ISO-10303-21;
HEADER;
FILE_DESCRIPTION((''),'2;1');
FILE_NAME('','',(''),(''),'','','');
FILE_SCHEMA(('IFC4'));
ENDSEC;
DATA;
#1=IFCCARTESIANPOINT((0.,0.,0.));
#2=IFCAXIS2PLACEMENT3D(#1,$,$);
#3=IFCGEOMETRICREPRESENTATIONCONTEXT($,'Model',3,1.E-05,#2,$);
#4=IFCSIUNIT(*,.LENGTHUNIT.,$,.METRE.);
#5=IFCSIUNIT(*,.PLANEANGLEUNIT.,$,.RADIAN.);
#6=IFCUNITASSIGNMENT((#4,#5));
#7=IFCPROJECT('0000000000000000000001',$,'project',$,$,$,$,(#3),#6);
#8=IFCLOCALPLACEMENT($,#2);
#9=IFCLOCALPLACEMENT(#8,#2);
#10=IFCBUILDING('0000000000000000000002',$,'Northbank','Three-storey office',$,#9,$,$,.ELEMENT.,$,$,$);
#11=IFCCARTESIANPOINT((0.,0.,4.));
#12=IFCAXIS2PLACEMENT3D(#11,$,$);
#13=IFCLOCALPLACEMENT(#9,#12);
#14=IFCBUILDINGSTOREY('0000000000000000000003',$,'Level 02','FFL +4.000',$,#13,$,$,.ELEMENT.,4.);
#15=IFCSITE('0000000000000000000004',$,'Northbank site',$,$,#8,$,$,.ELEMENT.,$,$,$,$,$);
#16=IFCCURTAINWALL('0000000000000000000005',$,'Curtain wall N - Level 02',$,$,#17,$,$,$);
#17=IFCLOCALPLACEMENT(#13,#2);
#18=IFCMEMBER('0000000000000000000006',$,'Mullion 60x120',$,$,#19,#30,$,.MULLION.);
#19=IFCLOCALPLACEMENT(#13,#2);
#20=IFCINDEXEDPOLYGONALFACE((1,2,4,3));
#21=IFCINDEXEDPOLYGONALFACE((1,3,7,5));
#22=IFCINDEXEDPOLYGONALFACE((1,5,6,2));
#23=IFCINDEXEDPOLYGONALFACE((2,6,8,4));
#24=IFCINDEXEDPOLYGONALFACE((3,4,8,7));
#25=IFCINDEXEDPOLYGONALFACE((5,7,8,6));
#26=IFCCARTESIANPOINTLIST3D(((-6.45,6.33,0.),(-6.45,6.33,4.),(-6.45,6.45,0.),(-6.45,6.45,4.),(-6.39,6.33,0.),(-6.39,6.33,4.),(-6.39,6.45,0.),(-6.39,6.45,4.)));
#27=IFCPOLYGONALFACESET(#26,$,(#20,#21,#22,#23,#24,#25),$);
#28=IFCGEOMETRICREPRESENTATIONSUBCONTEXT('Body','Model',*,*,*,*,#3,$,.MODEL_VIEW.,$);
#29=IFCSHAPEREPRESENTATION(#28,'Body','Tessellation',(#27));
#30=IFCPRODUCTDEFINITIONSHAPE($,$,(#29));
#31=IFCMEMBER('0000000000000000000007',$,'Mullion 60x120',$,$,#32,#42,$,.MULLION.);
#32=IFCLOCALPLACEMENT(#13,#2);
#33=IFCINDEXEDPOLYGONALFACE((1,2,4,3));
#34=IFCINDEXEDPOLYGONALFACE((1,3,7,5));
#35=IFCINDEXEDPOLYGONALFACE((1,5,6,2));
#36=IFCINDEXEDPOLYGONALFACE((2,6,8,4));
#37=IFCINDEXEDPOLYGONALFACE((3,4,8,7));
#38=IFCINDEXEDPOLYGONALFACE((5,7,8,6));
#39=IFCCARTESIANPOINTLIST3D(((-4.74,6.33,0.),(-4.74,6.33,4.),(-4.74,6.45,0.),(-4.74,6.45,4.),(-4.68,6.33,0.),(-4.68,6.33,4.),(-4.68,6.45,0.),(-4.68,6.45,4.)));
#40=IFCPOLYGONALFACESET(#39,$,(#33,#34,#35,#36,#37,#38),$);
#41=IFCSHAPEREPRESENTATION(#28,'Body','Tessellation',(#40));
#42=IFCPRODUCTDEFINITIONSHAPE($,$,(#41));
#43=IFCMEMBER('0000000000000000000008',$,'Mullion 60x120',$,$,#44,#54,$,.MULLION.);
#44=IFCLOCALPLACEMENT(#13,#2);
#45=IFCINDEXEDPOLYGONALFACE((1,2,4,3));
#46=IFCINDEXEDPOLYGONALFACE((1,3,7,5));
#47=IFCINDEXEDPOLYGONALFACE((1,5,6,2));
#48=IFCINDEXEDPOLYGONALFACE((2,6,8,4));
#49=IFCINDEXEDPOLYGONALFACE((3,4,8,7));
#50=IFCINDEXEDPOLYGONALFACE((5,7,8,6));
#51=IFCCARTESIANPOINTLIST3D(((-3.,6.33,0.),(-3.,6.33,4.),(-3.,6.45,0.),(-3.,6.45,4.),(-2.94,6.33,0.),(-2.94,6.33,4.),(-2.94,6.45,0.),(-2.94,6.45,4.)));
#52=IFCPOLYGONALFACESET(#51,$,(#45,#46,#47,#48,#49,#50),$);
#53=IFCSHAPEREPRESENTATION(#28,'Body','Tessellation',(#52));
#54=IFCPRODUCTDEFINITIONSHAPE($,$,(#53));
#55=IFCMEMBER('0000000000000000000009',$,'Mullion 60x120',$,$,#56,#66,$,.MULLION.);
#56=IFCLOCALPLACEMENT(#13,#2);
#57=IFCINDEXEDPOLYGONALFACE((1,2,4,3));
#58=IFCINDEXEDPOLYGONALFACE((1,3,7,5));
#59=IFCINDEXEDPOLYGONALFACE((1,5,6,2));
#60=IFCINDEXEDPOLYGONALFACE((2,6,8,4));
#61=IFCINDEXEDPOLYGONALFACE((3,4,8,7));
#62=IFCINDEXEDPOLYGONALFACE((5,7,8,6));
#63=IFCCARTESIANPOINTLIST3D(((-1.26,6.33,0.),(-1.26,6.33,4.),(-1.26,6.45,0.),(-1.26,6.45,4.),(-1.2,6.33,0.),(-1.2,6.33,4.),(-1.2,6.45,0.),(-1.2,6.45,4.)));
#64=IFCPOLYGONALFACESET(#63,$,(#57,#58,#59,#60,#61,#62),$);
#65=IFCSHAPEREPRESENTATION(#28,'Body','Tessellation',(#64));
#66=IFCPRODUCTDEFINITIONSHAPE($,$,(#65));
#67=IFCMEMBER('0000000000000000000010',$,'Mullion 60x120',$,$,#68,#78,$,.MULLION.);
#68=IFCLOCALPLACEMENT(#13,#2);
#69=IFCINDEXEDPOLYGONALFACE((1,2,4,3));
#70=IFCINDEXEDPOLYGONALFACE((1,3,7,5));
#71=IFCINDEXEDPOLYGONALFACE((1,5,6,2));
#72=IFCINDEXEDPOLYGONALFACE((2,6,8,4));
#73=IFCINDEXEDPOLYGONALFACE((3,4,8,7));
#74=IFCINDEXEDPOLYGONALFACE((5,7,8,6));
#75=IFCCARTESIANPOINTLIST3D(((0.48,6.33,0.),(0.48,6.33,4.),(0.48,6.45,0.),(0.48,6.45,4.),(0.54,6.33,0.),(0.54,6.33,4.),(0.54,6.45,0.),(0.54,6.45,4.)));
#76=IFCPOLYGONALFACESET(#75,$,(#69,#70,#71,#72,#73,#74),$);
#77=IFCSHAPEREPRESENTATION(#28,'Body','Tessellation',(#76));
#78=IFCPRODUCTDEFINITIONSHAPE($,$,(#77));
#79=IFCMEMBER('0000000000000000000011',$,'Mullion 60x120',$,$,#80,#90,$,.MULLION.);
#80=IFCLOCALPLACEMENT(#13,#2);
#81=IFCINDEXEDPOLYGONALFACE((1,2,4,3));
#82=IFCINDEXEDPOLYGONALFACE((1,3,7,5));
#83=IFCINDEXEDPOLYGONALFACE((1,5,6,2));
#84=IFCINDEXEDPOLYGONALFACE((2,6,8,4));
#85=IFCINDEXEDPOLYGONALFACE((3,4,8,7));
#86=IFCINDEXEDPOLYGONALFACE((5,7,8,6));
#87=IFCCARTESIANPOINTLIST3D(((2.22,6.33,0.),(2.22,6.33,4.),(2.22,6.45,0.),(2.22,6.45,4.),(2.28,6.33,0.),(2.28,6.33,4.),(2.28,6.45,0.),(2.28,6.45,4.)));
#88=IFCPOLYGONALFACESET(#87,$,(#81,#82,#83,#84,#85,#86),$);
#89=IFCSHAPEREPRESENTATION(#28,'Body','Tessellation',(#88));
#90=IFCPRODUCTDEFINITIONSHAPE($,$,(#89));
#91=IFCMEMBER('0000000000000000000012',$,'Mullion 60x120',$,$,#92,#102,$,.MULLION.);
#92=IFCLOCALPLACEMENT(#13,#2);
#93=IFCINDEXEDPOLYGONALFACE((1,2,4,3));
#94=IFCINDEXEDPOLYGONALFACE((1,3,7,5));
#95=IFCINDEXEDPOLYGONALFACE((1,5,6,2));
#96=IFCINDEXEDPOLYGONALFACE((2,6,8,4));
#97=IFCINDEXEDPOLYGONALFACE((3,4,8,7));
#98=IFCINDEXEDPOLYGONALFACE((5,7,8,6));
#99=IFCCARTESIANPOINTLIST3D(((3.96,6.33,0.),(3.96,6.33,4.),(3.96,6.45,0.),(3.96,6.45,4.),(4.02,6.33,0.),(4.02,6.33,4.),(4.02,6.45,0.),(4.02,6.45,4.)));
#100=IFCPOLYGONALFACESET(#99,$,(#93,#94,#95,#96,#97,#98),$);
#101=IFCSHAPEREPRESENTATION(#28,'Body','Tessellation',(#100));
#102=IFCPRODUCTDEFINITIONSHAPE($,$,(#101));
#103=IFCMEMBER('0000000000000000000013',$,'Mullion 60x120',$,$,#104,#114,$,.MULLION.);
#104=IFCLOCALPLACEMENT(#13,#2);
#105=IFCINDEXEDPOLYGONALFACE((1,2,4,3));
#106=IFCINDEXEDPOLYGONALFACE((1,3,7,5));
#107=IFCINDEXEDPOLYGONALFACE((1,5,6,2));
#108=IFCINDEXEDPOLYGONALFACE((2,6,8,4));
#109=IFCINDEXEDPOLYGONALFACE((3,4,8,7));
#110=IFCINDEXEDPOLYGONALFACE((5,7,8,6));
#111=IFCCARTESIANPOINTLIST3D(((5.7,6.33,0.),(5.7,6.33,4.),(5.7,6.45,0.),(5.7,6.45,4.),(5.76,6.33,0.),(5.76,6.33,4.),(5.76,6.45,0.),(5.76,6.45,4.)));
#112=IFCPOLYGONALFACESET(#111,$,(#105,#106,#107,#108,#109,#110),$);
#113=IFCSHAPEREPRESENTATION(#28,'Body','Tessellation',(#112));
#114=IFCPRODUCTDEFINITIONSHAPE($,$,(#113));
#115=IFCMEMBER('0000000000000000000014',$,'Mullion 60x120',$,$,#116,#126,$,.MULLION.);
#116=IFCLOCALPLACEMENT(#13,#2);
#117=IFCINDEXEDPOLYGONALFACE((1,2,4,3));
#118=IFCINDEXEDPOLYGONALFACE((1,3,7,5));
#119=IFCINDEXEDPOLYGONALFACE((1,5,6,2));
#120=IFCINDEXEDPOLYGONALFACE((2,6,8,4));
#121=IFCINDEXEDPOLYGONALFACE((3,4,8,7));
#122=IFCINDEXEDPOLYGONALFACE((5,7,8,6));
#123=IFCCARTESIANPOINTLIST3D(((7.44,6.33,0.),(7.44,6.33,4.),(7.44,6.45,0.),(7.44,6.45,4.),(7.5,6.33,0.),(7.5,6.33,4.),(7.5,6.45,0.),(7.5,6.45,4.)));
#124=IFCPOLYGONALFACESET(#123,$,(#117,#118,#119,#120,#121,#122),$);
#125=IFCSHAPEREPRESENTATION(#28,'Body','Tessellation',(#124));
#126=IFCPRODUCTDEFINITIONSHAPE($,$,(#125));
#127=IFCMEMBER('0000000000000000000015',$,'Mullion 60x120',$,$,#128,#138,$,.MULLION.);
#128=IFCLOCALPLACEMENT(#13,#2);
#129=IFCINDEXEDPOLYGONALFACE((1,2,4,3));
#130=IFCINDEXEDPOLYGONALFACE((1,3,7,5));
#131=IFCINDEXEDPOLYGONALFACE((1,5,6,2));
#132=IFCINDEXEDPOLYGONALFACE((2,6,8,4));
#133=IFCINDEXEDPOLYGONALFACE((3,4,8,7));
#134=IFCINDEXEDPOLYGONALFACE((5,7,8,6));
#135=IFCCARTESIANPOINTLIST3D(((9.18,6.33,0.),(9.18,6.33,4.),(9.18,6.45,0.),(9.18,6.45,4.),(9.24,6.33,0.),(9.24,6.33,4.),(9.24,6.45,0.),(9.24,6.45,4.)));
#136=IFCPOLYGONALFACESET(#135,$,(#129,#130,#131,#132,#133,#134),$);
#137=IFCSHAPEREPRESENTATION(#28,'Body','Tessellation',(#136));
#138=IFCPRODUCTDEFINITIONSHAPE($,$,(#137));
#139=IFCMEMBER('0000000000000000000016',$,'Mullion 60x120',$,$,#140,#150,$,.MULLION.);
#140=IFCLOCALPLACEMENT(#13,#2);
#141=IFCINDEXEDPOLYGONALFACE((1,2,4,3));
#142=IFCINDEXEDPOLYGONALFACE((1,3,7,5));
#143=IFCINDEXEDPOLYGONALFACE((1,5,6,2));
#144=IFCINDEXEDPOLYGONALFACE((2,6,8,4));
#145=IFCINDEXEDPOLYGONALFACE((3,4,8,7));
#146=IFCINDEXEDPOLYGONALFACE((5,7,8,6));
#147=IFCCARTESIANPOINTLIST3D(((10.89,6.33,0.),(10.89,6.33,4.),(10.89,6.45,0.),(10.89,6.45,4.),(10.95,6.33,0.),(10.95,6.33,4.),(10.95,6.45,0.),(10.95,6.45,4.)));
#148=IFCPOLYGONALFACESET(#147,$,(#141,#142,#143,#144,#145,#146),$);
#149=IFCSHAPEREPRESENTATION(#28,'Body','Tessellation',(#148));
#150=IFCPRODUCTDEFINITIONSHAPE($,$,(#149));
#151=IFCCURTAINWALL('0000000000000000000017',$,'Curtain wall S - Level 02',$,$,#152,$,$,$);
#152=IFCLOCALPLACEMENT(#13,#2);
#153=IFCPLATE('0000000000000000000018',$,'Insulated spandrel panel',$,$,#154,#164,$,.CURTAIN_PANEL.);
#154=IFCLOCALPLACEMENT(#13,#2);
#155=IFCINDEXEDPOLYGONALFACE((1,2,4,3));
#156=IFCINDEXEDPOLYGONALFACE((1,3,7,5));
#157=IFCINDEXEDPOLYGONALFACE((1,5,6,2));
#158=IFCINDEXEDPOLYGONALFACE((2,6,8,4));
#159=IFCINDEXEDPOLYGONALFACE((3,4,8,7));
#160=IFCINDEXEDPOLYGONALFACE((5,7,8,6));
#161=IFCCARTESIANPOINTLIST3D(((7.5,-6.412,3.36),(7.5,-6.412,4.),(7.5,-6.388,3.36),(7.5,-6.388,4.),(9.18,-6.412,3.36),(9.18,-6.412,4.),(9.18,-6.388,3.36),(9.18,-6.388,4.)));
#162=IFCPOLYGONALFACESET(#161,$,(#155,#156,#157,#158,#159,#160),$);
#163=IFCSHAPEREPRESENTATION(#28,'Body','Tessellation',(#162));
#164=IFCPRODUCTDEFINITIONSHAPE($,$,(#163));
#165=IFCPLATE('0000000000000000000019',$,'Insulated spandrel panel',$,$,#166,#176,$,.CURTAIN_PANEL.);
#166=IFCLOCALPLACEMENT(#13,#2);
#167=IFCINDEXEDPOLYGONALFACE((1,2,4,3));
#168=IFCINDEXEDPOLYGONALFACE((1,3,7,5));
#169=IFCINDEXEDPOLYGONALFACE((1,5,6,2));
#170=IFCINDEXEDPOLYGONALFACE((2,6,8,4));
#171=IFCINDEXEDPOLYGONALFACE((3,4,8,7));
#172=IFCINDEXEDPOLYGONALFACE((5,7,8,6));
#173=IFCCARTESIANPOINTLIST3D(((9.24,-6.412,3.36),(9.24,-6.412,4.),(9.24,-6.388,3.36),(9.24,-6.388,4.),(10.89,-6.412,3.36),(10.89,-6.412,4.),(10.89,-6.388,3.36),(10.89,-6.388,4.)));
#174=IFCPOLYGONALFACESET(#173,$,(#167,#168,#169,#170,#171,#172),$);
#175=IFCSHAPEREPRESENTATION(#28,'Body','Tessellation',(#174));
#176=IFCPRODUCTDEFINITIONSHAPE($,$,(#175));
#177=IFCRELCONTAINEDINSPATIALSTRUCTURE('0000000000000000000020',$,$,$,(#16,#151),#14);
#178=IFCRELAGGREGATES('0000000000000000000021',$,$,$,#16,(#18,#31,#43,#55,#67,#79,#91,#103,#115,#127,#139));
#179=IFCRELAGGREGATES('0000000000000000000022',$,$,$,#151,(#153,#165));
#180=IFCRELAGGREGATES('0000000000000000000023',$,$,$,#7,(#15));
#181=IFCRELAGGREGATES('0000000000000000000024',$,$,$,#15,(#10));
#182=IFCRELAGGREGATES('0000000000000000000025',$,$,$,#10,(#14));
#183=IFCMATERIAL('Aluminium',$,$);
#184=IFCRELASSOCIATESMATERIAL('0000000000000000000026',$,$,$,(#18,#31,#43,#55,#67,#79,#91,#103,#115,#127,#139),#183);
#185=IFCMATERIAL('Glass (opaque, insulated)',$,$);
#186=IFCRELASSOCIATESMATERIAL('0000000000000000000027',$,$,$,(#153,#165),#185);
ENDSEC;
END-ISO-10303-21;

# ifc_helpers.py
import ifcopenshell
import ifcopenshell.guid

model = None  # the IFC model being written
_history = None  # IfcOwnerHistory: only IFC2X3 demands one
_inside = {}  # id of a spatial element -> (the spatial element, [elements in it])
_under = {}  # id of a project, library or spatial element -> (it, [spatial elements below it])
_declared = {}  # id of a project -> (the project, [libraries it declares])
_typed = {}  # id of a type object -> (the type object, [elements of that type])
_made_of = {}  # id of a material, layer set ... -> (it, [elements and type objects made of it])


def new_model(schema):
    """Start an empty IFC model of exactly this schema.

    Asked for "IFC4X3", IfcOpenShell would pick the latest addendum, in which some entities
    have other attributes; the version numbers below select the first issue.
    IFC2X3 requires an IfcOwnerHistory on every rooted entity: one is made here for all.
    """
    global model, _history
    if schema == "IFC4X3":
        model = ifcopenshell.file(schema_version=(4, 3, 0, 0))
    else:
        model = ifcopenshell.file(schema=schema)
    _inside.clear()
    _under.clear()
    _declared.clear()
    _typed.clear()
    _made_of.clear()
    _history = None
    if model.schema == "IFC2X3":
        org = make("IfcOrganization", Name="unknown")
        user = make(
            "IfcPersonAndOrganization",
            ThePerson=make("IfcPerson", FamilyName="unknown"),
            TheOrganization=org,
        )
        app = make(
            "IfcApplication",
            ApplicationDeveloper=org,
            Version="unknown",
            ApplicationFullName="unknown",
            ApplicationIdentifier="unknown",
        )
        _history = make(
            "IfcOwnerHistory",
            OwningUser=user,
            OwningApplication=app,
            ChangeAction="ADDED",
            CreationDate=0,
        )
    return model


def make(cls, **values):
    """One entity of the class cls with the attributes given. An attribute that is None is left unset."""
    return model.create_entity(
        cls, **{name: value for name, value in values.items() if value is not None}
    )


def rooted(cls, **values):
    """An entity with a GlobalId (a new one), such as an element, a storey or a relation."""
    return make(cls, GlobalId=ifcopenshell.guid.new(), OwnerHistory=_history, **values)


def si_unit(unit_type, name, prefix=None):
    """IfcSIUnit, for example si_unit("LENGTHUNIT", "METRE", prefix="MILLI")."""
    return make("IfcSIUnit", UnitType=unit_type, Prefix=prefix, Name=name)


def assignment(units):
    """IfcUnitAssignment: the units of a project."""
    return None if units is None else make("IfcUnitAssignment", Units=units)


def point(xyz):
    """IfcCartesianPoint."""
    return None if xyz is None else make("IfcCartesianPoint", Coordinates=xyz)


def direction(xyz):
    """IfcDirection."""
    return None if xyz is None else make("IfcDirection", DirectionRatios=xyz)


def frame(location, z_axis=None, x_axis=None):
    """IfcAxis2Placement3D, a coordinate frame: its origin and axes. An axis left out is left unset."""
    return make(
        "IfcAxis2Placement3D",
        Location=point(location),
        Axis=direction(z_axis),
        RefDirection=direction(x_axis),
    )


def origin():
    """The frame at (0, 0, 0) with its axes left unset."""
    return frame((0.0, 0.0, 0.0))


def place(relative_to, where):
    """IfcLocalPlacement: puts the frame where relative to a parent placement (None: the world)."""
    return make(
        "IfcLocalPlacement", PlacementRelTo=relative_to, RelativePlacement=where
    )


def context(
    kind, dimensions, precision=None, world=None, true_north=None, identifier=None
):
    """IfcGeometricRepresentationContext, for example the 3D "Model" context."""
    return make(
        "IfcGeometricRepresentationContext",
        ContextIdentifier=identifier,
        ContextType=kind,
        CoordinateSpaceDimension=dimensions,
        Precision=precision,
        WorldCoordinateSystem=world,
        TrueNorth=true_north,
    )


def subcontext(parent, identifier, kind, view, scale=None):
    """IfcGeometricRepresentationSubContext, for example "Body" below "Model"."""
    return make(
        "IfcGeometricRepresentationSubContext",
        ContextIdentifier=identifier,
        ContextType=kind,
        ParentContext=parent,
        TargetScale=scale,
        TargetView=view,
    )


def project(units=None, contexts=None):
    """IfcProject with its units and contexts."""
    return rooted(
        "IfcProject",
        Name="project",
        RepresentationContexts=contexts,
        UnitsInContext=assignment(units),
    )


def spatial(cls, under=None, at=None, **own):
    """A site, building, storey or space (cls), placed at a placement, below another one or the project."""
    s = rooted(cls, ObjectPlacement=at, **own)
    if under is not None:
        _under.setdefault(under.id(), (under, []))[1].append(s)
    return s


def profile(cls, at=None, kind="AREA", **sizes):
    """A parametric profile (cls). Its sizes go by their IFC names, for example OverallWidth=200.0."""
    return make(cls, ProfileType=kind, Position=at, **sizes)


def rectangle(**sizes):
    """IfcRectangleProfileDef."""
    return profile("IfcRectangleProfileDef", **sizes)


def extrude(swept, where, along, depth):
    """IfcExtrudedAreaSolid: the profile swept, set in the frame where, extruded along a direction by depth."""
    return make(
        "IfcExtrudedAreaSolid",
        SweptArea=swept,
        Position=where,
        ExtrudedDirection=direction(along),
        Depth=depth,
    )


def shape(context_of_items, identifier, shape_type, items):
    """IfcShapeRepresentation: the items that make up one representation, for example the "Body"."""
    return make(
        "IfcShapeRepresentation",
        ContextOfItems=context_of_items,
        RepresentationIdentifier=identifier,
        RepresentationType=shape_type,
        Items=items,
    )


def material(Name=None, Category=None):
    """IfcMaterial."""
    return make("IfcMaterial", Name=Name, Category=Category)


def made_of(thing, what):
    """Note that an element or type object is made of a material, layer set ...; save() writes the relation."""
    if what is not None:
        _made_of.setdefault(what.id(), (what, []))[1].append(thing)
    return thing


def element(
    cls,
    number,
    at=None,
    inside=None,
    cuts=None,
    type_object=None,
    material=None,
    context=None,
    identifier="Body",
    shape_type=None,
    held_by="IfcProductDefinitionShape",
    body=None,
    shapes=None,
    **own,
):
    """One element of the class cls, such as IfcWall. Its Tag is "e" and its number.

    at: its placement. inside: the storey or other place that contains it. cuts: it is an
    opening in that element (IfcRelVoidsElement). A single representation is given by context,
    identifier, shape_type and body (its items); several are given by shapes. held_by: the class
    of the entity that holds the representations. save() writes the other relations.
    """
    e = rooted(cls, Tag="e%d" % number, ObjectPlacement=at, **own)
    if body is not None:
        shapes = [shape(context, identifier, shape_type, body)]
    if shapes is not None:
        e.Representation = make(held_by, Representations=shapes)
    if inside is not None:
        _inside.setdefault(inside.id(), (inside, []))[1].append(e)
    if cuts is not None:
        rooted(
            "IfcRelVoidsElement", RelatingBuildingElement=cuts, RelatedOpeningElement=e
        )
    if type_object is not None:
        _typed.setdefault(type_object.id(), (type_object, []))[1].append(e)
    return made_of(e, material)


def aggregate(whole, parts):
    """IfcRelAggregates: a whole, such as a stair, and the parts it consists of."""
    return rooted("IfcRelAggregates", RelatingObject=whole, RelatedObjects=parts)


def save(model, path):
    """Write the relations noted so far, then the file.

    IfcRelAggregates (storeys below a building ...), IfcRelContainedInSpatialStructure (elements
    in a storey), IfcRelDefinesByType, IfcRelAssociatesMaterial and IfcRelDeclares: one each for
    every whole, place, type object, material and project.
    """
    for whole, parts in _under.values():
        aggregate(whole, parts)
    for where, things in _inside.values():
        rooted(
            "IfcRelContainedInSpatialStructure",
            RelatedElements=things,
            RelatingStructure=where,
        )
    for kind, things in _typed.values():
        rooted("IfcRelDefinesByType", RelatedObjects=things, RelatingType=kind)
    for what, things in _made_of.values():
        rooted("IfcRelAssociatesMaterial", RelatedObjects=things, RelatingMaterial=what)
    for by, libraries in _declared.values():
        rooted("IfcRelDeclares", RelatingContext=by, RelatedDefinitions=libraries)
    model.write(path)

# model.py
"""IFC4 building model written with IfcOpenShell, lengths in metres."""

from ifc_helpers import new_model, si_unit, frame, origin, place, context, subcontext, project, spatial, rectangle, extrude, material, element, aggregate, save


model = new_model("IFC4")

# Units and contexts
model_context = context("Model", 3, precision=1e-05, world=origin())
body_context = subcontext(model_context, "Body", "Model", "MODEL_VIEW")
ifc_project = project(units=[si_unit("LENGTHUNIT", "METRE"), si_unit("PLANEANGLEUNIT", "RADIAN")], contexts=[model_context])

# Site, building, storey
site_placement = place(None, origin())
site = spatial("IfcSite", under=ifc_project, at=site_placement, Name="Northbank site", CompositionType="ELEMENT")
building_placement = place(site_placement, origin())
building = spatial("IfcBuilding", under=site, at=building_placement, Name="Northbank", Description="Three-storey office", CompositionType="ELEMENT")
storey_placement = place(building_placement, frame((0.0, 0.0, 4.0)))
storey = spatial("IfcBuildingStorey", under=building, at=storey_placement, Name="Level 02", Description="FFL +4.000", CompositionType="ELEMENT", Elevation=4.0)

# Curtain wall, members
curtain_wall_1_placement = place(storey_placement, frame((0.0, 0.0, -4.0)))
curtain_wall_1 = element("IfcCurtainWall", 1, at=curtain_wall_1_placement, inside=storey, Name="Curtain wall N - Level 02")
ifc_material_1 = material(Name="Aluminium")
member_1_placement = place(storey_placement, frame((0.0, 0.0, -4.0)))
member_1 = element("IfcMember", 2, at=member_1_placement, material=ifc_material_1, Name="Mullion 60x120", PredefinedType="MULLION", context=body_context, shape_type="SweptSolid", body=[
    extrude(rectangle(XDim=0.06, YDim=0.12), frame((-6.42, 6.39, 4.0)), (0.0, 0.0, 1.0), 4.0),
])
member_2_placement = place(storey_placement, frame((0.0, 0.0, -4.0)))
member_2 = element("IfcMember", 3, at=member_2_placement, material=ifc_material_1, Name="Mullion 60x120", PredefinedType="MULLION", context=body_context, shape_type="SweptSolid", body=[
    extrude(rectangle(XDim=0.06, YDim=0.12), frame((-4.71, 6.39, 4.0)), (0.0, 0.0, 1.0), 4.0),
])
member_3_placement = place(storey_placement, frame((0.0, 0.0, -4.0)))
member_3 = element("IfcMember", 4, at=member_3_placement, material=ifc_material_1, Name="Mullion 60x120", PredefinedType="MULLION", context=body_context, shape_type="SweptSolid", body=[
    extrude(rectangle(XDim=0.06, YDim=0.12), frame((-2.97, 6.39, 4.0)), (0.0, 0.0, 1.0), 4.0),
])
member_4_placement = place(storey_placement, frame((0.0, 0.0, -4.0)))
member_4 = element("IfcMember", 5, at=member_4_placement, material=ifc_material_1, Name="Mullion 60x120", PredefinedType="MULLION", context=body_context, shape_type="SweptSolid", body=[
    extrude(rectangle(XDim=0.06, YDim=0.12), frame((-1.23, 6.39, 4.0)), (0.0, 0.0, 1.0), 4.0),
])
member_5_placement = place(storey_placement, frame((0.0, 0.0, -4.0)))
member_5 = element("IfcMember", 6, at=member_5_placement, material=ifc_material_1, Name="Mullion 60x120", PredefinedType="MULLION", context=body_context, shape_type="SweptSolid", body=[
    extrude(rectangle(XDim=0.06, YDim=0.12), frame((0.51, 6.39, 4.0)), (0.0, 0.0, 1.0), 4.0),
])
member_6_placement = place(storey_placement, frame((0.0, 0.0, -4.0)))
member_6 = element("IfcMember", 7, at=member_6_placement, material=ifc_material_1, Name="Mullion 60x120", PredefinedType="MULLION", context=body_context, shape_type="SweptSolid", body=[
    extrude(rectangle(XDim=0.06, YDim=0.12), frame((2.25, 6.39, 4.0)), (0.0, 0.0, 1.0), 4.0),
])
member_7_placement = place(storey_placement, frame((0.0, 0.0, -4.0)))
member_7 = element("IfcMember", 8, at=member_7_placement, material=ifc_material_1, Name="Mullion 60x120", PredefinedType="MULLION", context=body_context, shape_type="SweptSolid", body=[
    extrude(rectangle(XDim=0.06, YDim=0.12), frame((3.99, 6.39, 4.0)), (0.0, 0.0, 1.0), 4.0),
])
member_8_placement = place(storey_placement, frame((0.0, 0.0, -4.0)))
member_8 = element("IfcMember", 9, at=member_8_placement, material=ifc_material_1, Name="Mullion 60x120", PredefinedType="MULLION", context=body_context, shape_type="SweptSolid", body=[
    extrude(rectangle(XDim=0.06, YDim=0.12), frame((5.73, 6.39, 4.0)), (0.0, 0.0, 1.0), 4.0),
])
member_9_placement = place(storey_placement, frame((0.0, 0.0, -4.0)))
member_9 = element("IfcMember", 10, at=member_9_placement, material=ifc_material_1, Name="Mullion 60x120", PredefinedType="MULLION", context=body_context, shape_type="SweptSolid", body=[
    extrude(rectangle(XDim=0.06, YDim=0.12), frame((7.47, 6.39, 4.0)), (0.0, 0.0, 1.0), 4.0),
])
member_10_placement = place(storey_placement, frame((0.0, 0.0, -4.0)))
member_10 = element("IfcMember", 11, at=member_10_placement, material=ifc_material_1, Name="Mullion 60x120", PredefinedType="MULLION", context=body_context, shape_type="SweptSolid", body=[
    extrude(rectangle(XDim=0.06, YDim=0.12), frame((9.21, 6.39, 4.0)), (0.0, 0.0, 1.0), 4.0),
])
member_11_placement = place(storey_placement, frame((0.0, 0.0, -4.0)))
member_11 = element("IfcMember", 12, at=member_11_placement, material=ifc_material_1, Name="Mullion 60x120", PredefinedType="MULLION", context=body_context, shape_type="SweptSolid", body=[
    extrude(rectangle(XDim=0.06, YDim=0.12), frame((10.92, 6.39, 4.0)), (0.0, 0.0, 1.0), 4.0),
])
aggregate(curtain_wall_1, [member_1, member_2, member_3, member_4, member_5, member_6, member_7, member_8, member_9, member_10, member_11])

# Curtain wall, plates
curtain_wall_2_placement = place(storey_placement, frame((0.0, 0.0, -4.0)))
curtain_wall_2 = element("IfcCurtainWall", 13, at=curtain_wall_2_placement, inside=storey, Name="Curtain wall S - Level 02")
ifc_material_2 = material(Name="Glass (opaque, insulated)")
plate_1_placement = place(storey_placement, frame((0.0, 0.0, -4.0)))
plate_1 = element("IfcPlate", 14, at=plate_1_placement, material=ifc_material_2, Name="Insulated spandrel panel", PredefinedType="CURTAIN_PANEL", context=body_context, shape_type="SweptSolid", body=[
    extrude(rectangle(XDim=1.68, YDim=0.024), frame((8.34, -6.4, 7.36)), (0.0, 0.0, 1.0), 0.64),
])
plate_2_placement = place(storey_placement, frame((0.0, 0.0, -4.0)))
plate_2 = element("IfcPlate", 15, at=plate_2_placement, material=ifc_material_2, Name="Insulated spandrel panel", PredefinedType="CURTAIN_PANEL", context=body_context, shape_type="SweptSolid", body=[
    extrude(rectangle(XDim=1.65, YDim=0.024), frame((10.065, -6.4, 7.36)), (0.0, 0.0, 1.0), 0.64),
])
aggregate(curtain_wall_2, [plate_1, plate_2])

save(model, "model.ifc")
